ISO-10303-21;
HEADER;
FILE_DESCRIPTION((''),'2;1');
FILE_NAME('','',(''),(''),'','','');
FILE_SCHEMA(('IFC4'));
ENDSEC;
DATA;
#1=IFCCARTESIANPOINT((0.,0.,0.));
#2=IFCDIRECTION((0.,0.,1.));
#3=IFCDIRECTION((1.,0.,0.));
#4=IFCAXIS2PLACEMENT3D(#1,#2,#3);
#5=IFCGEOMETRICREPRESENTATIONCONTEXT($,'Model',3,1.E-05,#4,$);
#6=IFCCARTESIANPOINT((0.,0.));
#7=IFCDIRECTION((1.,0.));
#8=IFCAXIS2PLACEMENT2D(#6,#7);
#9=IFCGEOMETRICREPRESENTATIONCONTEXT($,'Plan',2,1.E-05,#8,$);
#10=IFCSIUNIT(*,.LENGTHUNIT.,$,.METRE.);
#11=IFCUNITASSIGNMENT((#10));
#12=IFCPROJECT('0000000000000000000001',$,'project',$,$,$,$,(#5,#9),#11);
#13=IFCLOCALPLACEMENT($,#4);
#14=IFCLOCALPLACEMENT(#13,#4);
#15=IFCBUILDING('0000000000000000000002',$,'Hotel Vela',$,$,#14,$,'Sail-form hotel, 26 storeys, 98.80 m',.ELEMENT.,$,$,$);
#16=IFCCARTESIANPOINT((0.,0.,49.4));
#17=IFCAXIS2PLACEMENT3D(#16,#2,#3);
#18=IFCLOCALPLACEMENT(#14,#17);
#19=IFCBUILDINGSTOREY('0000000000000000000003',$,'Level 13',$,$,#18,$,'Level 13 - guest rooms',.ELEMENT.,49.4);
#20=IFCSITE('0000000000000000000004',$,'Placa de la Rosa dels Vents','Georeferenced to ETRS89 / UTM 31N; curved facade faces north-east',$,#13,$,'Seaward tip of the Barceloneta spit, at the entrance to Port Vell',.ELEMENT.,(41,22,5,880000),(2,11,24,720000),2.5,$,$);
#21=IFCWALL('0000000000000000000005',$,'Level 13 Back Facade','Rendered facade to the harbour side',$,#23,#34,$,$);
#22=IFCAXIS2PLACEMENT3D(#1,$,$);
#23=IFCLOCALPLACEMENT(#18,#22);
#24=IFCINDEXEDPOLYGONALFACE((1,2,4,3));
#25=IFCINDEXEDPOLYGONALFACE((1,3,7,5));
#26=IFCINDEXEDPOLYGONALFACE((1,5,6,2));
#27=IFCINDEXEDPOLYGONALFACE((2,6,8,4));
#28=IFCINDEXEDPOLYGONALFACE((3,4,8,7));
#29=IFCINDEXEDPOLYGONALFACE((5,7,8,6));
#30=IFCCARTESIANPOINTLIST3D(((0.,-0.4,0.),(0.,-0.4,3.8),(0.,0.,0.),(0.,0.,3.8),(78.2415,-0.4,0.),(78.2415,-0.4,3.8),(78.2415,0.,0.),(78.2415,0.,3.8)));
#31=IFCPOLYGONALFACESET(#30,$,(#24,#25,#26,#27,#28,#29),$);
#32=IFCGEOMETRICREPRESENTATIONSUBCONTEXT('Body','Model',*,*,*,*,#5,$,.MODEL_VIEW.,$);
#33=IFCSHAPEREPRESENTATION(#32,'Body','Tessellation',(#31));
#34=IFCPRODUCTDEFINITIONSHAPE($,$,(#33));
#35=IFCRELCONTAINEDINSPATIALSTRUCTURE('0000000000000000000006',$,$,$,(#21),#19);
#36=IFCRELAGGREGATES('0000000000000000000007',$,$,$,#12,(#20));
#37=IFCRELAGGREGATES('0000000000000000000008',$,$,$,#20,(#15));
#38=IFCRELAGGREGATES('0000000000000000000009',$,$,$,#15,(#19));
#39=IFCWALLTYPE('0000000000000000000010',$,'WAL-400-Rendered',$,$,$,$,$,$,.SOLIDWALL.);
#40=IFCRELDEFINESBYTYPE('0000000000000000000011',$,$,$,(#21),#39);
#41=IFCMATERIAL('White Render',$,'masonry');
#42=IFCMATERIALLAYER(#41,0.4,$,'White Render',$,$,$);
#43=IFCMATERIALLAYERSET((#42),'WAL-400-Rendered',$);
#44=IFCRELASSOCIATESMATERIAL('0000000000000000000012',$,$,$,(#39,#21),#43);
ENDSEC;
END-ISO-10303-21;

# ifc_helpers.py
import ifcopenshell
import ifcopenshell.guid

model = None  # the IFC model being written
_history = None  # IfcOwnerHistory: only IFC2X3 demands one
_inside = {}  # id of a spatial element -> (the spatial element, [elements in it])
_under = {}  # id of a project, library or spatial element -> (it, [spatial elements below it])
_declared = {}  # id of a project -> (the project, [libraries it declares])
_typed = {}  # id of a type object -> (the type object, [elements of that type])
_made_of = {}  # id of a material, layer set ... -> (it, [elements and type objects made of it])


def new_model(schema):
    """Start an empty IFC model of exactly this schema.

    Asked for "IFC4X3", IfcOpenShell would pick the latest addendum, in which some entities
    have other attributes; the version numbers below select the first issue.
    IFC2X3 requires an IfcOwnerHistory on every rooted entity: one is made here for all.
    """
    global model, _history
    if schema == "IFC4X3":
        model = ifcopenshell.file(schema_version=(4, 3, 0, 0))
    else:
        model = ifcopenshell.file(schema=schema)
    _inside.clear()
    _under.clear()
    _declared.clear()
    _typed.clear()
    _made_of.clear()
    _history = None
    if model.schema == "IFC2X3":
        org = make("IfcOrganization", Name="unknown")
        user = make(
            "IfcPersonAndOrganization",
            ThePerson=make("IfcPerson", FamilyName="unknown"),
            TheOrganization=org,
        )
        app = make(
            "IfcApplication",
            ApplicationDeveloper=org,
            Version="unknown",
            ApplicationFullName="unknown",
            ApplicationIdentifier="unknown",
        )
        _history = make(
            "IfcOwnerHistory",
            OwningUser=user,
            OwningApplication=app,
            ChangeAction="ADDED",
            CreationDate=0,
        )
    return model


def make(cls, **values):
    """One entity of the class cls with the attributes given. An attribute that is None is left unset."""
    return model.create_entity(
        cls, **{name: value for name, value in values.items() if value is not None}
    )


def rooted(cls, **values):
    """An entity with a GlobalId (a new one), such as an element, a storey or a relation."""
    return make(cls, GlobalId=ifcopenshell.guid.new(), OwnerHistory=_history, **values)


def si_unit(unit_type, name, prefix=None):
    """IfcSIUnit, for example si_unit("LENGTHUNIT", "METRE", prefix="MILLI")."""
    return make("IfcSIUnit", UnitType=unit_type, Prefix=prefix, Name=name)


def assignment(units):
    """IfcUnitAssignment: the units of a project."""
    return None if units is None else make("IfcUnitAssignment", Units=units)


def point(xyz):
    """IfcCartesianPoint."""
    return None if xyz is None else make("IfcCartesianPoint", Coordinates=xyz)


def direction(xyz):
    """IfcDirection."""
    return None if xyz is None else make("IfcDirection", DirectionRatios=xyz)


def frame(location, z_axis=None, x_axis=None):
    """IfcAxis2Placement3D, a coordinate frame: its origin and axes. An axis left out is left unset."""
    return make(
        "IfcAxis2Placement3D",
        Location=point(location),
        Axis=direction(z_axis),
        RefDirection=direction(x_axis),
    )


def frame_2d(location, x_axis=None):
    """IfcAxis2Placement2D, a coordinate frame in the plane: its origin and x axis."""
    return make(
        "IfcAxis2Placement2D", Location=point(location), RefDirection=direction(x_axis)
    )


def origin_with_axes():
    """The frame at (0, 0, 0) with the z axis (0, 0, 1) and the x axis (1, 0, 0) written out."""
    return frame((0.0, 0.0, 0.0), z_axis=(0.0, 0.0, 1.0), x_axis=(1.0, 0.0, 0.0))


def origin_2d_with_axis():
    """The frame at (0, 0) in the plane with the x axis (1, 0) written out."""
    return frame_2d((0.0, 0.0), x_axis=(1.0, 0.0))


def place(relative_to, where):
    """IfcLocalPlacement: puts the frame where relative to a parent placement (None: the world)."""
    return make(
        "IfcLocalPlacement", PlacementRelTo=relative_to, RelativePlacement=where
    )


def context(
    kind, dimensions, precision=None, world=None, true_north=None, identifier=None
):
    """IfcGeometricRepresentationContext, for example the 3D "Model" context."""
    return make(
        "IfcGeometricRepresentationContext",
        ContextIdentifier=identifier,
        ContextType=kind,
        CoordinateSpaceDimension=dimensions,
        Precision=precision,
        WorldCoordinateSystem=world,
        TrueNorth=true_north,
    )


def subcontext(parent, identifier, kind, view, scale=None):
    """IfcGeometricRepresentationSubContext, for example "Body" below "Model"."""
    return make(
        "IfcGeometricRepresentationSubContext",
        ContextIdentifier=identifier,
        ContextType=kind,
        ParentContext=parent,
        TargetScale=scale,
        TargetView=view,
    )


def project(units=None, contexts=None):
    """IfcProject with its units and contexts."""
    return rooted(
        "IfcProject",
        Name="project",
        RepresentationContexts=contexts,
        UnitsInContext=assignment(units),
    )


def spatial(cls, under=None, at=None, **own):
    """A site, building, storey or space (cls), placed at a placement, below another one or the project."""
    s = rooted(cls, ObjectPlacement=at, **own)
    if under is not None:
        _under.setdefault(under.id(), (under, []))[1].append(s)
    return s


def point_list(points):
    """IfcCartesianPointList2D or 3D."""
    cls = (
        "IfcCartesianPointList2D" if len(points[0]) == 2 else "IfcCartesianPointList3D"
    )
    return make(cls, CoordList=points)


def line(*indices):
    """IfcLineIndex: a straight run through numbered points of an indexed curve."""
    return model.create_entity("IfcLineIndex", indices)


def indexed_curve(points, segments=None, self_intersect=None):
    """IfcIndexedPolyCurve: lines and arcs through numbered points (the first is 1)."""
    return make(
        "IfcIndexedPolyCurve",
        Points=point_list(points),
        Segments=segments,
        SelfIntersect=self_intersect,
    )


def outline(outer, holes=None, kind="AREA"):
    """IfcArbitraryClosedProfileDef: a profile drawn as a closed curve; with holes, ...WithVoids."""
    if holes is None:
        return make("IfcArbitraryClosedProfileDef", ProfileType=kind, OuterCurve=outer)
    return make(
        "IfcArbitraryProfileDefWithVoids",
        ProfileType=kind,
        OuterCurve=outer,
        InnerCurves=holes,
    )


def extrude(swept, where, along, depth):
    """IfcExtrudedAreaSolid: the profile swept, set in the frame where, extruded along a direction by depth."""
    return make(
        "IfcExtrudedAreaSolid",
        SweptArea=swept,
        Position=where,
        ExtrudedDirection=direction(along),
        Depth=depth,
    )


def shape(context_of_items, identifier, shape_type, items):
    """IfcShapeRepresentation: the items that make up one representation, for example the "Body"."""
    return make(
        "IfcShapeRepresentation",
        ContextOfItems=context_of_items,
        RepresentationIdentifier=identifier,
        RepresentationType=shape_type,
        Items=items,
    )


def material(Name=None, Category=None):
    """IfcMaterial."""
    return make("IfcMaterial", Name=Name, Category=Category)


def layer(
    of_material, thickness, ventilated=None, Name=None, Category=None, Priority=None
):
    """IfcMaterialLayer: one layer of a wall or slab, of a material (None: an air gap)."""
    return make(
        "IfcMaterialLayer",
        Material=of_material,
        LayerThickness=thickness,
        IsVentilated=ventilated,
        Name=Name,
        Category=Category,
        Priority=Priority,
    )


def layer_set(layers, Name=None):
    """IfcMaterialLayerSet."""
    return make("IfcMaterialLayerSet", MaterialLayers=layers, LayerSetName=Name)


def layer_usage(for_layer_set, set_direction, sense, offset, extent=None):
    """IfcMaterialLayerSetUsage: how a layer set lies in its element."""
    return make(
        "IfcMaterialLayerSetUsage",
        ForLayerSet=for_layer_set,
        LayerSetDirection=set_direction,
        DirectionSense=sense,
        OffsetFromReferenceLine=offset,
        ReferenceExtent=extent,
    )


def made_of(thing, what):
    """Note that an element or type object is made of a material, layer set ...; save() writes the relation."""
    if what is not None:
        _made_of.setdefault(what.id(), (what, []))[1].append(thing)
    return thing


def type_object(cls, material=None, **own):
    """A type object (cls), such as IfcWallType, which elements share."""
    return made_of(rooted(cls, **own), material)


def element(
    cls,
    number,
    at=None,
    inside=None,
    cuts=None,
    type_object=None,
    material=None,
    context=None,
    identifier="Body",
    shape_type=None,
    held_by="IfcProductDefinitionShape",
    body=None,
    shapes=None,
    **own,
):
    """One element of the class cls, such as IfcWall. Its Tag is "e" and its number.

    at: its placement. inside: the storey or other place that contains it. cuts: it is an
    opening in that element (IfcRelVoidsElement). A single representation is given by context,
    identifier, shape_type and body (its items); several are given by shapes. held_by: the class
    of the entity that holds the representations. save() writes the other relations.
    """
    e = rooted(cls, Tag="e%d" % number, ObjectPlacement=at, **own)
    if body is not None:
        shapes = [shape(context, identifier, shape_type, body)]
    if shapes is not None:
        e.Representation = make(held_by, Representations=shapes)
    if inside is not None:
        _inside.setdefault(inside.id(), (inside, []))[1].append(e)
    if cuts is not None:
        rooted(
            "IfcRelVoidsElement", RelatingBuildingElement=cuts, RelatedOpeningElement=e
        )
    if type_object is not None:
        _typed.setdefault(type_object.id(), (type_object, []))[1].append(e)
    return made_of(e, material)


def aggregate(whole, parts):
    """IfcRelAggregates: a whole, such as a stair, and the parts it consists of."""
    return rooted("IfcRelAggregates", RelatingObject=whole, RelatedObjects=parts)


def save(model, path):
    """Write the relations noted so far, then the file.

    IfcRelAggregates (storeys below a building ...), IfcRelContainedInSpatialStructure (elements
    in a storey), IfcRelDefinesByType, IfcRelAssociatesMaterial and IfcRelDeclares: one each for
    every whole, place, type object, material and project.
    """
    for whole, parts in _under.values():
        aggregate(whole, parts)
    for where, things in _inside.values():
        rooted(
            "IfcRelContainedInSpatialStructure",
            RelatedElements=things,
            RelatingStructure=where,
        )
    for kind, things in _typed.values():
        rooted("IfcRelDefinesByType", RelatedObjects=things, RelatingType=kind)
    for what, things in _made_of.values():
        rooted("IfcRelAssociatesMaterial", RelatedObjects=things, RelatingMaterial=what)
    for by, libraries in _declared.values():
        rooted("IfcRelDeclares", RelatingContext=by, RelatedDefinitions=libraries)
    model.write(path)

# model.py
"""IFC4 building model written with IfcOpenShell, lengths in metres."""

from ifc_helpers import new_model, si_unit, frame, origin_with_axes, origin_2d_with_axis, place, context, subcontext, project, spatial, line, indexed_curve, outline, extrude, material, layer, layer_set, layer_usage, type_object, element, save


model = new_model("IFC4")

# Units and contexts
model_context = context("Model", 3, precision=1e-05, world=origin_with_axes())
plan_context = context("Plan", 2, precision=1e-05, world=origin_2d_with_axis())
body_context = subcontext(model_context, "Body", "Model", "MODEL_VIEW")
ifc_project = project(units=[si_unit("LENGTHUNIT", "METRE")], contexts=[model_context, plan_context])

# Site, building, storey
site_placement = place(None, origin_with_axes())
site = spatial("IfcSite", under=ifc_project, at=site_placement, Name="Placa de la Rosa dels Vents", Description="Georeferenced to ETRS89 / UTM 31N; curved facade faces north-east", LongName="Seaward tip of the Barceloneta spit, at the entrance to Port Vell", CompositionType="ELEMENT", RefLatitude=(41, 22, 5, 880000), RefLongitude=(2, 11, 24, 720000), RefElevation=2.5)
building_placement = place(site_placement, origin_with_axes())
building = spatial("IfcBuilding", under=site, at=building_placement, Name="Hotel Vela", LongName="Sail-form hotel, 26 storeys, 98.80 m", CompositionType="ELEMENT")
storey_placement = place(building_placement, frame((0.0, 0.0, 49.4), z_axis=(0.0, 0.0, 1.0), x_axis=(1.0, 0.0, 0.0)))
storey = spatial("IfcBuildingStorey", under=building, at=storey_placement, Name="Level 13", LongName="Level 13 - guest rooms", CompositionType="ELEMENT", Elevation=49.4)

# Wall
ifc_material_1 = material(Name="White Render", Category="masonry")
ifc_layer_1 = layer(ifc_material_1, 0.4, Name="White Render")
ifc_layer_set_1 = layer_set([ifc_layer_1], Name="WAL-400-Rendered")
ifc_layer_usage_1 = layer_usage(ifc_layer_set_1, "AXIS2", "POSITIVE", 0.0)
wall_type = type_object("IfcWallType", Name="WAL-400-Rendered", PredefinedType="SOLIDWALL", material=ifc_layer_set_1)
wall_placement = place(storey_placement, frame((0.0, -0.4, 0.0), z_axis=(0.0, 0.0, 1.0), x_axis=(1.0, 0.0, 0.0)))
element("IfcWall", 1, at=wall_placement, inside=storey, type_object=wall_type, material=ifc_layer_usage_1, Name="Level 13 Back Facade", Description="Rendered facade to the harbour side", context=body_context, shape_type="SweptSolid", body=[
    extrude(outline(indexed_curve([(0.0, 0.0), (78.2415, 0.0), (78.2415, 0.4), (0.0, 0.4)], segments=[line(1, 2, 3, 4, 1)])), origin_with_axes(), (0.0, 0.0, 1.0), 3.8),
])

save(model, "model.ifc")
